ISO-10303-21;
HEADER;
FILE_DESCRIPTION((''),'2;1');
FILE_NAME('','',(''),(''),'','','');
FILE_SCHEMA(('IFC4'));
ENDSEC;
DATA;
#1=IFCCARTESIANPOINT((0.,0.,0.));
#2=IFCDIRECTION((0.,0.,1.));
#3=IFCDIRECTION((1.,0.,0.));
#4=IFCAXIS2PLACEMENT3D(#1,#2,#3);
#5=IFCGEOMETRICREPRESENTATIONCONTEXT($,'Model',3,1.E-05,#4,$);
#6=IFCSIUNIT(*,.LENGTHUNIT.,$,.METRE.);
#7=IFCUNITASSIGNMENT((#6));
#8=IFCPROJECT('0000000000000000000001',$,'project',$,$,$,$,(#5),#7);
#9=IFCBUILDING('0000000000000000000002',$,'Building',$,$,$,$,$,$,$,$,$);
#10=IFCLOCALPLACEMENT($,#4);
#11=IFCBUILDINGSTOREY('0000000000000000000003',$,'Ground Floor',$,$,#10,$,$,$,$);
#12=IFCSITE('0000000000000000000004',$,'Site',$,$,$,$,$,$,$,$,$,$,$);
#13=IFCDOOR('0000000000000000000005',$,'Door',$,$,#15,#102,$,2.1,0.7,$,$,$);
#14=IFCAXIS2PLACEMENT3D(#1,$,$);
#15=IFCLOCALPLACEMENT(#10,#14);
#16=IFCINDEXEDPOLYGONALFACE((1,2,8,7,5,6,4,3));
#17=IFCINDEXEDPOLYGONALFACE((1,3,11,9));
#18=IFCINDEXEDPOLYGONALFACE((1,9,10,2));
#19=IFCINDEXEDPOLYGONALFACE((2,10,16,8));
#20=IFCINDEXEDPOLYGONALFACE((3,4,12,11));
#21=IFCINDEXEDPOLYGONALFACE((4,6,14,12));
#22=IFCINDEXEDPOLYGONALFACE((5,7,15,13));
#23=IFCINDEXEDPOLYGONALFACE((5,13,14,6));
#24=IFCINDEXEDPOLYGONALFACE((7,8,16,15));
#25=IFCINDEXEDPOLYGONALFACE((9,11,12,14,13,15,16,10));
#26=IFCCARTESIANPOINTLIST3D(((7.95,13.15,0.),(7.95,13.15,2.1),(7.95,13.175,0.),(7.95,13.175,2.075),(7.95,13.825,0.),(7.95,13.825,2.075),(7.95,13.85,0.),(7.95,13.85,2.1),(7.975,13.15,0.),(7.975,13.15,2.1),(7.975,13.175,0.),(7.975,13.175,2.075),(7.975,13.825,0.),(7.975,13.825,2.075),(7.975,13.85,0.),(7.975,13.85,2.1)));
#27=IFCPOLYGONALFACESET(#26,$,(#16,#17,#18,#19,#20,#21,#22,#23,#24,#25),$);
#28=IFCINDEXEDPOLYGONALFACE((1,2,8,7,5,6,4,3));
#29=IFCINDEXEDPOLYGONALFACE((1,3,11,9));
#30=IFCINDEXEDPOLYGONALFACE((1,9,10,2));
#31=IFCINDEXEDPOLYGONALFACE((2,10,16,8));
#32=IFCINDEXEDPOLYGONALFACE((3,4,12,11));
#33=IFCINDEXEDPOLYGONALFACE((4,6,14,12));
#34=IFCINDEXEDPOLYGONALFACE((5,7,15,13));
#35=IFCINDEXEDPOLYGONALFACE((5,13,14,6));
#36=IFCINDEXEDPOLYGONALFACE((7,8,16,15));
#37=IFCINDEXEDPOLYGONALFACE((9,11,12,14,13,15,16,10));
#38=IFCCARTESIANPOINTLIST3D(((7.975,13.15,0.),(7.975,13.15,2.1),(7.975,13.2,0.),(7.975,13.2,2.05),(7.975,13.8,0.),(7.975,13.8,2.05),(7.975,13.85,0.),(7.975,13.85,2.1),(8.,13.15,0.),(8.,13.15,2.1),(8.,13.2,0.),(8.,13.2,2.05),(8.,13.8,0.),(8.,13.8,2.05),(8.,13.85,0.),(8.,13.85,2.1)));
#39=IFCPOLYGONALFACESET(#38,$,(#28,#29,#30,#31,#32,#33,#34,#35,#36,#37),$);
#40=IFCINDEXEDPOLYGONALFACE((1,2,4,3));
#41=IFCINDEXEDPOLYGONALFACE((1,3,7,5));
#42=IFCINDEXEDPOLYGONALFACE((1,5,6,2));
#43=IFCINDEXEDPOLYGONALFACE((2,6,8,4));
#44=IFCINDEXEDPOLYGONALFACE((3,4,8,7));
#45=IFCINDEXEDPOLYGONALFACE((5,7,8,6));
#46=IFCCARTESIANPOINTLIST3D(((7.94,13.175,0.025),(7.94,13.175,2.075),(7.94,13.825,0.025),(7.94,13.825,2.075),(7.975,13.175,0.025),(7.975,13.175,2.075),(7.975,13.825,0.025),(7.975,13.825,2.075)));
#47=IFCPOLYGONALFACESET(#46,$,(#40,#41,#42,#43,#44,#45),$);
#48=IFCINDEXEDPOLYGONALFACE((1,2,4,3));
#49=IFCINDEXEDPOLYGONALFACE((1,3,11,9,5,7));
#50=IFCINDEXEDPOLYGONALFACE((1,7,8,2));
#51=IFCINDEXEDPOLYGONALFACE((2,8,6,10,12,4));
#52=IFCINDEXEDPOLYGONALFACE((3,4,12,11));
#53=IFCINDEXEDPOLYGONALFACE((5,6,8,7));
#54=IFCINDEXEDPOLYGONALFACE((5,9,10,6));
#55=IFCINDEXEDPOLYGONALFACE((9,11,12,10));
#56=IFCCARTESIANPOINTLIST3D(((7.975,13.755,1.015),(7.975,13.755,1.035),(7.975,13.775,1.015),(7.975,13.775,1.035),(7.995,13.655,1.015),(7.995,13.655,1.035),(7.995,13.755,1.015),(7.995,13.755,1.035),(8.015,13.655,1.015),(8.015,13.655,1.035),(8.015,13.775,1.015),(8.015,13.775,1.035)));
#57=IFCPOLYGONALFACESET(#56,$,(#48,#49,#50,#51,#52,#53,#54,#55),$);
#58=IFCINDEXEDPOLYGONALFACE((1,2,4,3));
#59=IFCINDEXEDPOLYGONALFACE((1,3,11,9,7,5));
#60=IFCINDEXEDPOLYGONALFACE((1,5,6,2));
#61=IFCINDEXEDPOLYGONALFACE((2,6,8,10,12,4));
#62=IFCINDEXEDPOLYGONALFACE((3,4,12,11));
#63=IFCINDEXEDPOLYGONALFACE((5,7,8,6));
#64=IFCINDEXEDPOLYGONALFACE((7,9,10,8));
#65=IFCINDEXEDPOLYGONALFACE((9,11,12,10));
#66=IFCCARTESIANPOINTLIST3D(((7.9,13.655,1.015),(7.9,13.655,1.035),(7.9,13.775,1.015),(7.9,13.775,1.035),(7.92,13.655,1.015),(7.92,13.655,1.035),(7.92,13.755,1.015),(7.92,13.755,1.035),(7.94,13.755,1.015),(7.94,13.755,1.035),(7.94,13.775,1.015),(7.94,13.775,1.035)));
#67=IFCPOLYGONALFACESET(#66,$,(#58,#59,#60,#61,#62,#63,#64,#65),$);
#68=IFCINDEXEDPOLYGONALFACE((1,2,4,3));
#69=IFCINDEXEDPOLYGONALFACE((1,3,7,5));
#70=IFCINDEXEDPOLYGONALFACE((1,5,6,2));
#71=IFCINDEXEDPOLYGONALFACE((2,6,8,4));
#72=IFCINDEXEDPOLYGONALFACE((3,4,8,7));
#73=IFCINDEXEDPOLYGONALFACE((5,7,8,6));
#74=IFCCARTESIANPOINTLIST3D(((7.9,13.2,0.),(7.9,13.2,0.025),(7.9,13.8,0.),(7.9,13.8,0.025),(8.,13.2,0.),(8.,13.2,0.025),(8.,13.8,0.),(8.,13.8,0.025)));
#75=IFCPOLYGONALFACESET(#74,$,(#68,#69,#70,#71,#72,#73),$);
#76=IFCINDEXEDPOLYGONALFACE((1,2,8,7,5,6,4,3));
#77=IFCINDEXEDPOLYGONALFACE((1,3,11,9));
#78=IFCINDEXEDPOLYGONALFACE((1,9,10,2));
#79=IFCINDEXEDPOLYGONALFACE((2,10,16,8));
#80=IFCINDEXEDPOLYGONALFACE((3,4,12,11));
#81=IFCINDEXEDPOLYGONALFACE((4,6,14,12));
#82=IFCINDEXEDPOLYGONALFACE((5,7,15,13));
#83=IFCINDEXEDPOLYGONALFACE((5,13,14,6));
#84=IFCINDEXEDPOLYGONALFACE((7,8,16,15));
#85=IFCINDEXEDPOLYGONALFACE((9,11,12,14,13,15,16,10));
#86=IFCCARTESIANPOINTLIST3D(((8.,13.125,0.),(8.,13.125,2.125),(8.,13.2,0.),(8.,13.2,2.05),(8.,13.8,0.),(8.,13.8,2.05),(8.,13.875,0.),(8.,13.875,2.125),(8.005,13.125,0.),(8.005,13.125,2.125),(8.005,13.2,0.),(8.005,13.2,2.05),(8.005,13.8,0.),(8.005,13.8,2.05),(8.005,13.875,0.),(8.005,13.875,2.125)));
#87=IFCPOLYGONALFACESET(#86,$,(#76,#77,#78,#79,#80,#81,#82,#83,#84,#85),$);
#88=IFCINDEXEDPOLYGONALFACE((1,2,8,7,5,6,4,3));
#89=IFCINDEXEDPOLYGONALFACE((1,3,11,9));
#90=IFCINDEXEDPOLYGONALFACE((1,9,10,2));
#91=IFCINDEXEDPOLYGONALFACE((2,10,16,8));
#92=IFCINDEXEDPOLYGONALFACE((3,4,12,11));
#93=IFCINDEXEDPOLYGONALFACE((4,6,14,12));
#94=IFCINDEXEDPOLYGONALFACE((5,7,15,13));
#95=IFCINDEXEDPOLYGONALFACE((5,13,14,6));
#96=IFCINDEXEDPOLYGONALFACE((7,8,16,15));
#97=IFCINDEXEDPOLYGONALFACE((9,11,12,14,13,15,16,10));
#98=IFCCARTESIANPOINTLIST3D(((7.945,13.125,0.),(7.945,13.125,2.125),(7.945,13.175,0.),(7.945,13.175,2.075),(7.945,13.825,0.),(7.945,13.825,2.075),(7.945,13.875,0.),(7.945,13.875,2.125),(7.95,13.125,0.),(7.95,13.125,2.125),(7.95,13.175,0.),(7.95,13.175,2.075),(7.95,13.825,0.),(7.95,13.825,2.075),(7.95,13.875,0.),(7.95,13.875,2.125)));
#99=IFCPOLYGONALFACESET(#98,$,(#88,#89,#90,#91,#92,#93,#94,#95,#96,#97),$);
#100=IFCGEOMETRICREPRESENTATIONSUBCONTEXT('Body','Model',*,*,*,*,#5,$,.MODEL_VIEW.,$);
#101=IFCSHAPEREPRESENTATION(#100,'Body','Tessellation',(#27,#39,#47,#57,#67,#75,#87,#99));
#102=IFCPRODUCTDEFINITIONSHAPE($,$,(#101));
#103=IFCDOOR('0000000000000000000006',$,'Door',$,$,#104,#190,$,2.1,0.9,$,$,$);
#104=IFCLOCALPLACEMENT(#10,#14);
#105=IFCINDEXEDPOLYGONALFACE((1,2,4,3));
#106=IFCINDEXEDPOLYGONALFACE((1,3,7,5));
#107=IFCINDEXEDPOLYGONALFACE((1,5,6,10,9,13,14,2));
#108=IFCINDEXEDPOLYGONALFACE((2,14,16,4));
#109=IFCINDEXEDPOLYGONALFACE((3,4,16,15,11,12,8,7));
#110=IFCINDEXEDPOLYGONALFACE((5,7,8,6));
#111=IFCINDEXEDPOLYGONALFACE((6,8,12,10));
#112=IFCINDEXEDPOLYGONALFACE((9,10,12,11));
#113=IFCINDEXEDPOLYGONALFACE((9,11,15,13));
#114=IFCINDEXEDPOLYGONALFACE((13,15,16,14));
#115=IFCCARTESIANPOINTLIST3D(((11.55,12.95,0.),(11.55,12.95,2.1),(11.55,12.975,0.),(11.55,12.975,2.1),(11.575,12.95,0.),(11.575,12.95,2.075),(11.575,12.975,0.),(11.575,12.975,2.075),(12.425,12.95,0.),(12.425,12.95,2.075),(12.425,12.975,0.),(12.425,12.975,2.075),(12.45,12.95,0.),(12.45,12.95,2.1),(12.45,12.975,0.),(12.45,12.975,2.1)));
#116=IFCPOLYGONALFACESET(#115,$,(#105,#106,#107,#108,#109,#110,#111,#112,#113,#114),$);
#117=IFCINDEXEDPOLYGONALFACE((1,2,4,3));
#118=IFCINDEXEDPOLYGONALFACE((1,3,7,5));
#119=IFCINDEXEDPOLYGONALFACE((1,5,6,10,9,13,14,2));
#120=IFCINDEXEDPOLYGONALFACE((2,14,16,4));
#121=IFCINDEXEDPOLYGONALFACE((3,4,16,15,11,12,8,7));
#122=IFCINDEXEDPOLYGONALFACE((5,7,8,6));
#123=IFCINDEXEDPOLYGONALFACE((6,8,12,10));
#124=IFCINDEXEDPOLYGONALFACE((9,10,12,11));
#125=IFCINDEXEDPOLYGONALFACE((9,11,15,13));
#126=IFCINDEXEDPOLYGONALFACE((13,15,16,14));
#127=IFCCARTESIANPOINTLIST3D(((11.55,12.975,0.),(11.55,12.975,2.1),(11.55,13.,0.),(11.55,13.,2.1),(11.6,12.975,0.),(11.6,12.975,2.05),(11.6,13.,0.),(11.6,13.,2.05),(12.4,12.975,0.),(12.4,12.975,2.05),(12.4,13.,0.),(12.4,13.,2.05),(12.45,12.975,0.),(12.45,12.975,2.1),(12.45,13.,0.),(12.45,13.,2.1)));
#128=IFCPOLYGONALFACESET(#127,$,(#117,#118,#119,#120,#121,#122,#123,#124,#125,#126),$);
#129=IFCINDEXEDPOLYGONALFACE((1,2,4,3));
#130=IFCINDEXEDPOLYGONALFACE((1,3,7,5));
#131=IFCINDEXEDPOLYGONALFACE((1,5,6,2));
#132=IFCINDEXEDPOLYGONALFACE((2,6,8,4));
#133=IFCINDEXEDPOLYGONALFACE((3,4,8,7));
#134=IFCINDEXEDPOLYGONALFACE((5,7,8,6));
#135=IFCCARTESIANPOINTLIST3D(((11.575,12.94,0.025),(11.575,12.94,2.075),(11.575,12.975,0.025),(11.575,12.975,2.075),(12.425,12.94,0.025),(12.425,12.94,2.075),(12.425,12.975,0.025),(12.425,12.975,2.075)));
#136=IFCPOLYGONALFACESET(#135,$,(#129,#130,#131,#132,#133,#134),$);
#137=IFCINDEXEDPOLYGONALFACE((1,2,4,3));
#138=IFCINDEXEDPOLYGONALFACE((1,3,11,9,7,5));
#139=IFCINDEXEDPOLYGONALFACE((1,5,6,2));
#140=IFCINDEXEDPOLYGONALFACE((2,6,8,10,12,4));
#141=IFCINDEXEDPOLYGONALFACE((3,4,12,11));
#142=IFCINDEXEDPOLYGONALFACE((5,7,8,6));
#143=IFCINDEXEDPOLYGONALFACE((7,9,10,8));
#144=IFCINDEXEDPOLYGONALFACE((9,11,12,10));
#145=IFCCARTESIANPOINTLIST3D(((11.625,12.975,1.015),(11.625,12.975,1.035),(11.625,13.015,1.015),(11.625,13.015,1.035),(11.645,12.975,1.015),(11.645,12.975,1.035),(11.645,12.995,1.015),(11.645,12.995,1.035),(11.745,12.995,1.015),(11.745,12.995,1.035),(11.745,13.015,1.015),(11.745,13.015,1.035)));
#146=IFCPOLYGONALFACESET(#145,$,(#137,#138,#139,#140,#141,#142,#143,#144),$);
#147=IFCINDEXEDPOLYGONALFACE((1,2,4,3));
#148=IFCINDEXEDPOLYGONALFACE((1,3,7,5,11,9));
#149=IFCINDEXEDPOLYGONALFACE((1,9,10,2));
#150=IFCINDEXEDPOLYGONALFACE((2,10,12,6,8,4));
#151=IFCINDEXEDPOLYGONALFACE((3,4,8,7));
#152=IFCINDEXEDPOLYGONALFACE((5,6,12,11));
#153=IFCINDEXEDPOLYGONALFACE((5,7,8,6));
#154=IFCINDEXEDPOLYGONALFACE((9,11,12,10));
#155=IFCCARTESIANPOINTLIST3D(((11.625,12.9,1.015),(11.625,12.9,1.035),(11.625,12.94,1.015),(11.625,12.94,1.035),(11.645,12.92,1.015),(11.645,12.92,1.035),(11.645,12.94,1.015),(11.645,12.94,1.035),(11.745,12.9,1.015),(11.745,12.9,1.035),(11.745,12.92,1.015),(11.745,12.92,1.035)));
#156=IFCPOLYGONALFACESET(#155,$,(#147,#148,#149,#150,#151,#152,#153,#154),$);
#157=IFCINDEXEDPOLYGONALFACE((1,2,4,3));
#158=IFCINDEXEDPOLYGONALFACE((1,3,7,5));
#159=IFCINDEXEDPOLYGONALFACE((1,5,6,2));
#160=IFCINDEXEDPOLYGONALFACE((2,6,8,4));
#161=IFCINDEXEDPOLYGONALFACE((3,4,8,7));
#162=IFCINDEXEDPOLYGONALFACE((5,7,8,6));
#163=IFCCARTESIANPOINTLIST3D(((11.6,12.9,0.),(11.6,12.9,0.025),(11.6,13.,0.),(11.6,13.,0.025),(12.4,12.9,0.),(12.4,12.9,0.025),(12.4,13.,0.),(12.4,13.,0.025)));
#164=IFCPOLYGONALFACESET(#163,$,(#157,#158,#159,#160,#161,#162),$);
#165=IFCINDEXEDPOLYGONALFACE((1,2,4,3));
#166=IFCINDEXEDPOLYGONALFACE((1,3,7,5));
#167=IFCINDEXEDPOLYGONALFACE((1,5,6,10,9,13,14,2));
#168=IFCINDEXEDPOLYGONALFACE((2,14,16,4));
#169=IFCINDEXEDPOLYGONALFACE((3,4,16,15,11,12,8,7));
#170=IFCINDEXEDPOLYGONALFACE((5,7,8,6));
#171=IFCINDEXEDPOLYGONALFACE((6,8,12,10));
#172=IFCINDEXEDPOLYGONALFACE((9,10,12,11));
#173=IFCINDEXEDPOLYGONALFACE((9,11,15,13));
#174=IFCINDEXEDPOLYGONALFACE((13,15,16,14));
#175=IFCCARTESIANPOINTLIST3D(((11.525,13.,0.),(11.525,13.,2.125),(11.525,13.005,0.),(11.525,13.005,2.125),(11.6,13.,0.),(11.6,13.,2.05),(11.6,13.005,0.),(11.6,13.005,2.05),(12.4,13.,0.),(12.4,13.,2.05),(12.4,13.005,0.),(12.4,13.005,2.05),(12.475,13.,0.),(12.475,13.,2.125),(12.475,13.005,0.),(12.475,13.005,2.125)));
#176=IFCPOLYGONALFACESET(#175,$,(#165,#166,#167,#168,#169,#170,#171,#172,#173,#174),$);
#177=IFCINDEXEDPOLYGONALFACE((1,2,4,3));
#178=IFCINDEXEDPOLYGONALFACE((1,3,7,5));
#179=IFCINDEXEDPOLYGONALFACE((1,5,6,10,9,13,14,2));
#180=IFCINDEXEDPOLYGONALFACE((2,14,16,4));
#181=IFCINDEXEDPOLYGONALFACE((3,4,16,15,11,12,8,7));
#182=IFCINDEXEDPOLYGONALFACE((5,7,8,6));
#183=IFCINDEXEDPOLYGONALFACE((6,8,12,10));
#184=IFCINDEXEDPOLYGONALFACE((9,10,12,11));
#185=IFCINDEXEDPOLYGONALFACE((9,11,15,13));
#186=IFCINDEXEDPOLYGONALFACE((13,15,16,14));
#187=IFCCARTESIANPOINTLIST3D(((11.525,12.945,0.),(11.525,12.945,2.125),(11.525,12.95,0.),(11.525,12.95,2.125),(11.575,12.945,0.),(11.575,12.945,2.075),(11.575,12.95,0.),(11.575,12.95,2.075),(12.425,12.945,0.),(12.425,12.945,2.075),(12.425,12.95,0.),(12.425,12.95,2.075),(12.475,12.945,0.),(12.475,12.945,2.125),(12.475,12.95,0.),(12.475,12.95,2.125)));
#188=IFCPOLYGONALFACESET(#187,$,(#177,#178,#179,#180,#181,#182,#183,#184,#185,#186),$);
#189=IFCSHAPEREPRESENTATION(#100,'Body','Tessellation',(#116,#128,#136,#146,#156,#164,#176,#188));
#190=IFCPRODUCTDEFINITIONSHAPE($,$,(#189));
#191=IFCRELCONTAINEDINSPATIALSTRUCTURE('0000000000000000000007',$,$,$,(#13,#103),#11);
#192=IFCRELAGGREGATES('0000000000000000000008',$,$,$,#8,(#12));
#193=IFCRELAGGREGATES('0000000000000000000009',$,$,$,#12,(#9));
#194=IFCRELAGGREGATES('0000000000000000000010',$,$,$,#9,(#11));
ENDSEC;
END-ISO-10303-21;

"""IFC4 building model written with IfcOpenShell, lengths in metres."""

from ifc_helpers import new_model, si_unit, frame, origin_with_axes, place, context, subcontext, project, spatial, line, indexed_curve, outline, extrude, element, save


model = new_model("IFC4")

# Units and contexts
model_context = context("Model", 3, precision=1e-05, world=origin_with_axes())
body_context = subcontext(model_context, "Body", "Model", "MODEL_VIEW")
ifc_project = project(units=[si_unit("LENGTHUNIT", "METRE")], contexts=[model_context])

# Site, building, storey
site = spatial("IfcSite", under=ifc_project, Name="Site")
building = spatial("IfcBuilding", under=site, Name="Building")
storey_placement = place(None, origin_with_axes())
storey = spatial("IfcBuildingStorey", under=building, at=storey_placement, Name="Ground Floor")

# Doors
door_1_placement = place(storey_placement, frame((8.0, 13.15, 0.0), z_axis=(0.0, 0.0, 1.0), x_axis=(0.0, 1.0, 0.0)))
element("IfcDoor", 1, at=door_1_placement, inside=storey, Name="Door", OverallHeight=2.1, OverallWidth=0.7, context=body_context, shape_type="SweptSolid", body=[
    extrude(outline(indexed_curve([(0.0, 0.0), (0.0, 2.1), (0.7, 2.1), (0.7, 0.0), (0.675, 0.0), (0.675, 2.075), (0.025, 2.075), (0.025, 0.0)], segments=[line(1, 2, 3, 4, 5, 6, 7, 8, 1)])), frame((0.0, 0.025, 0.0), z_axis=(0.0, -1.0, 0.0), x_axis=(1.0, 0.0, 0.0)), (0.0, 0.0, -1.0), 0.025),
    extrude(outline(indexed_curve([(0.0, 0.0), (0.0, 2.1), (0.7, 2.1), (0.7, 0.0), (0.65, 0.0), (0.65, 2.05), (0.05, 2.05), (0.05, 0.0)], segments=[line(1, 2, 3, 4, 5, 6, 7, 8, 1)])), frame((0.0, 0.0, 0.0), z_axis=(0.0, -1.0, 0.0), x_axis=(1.0, 0.0, 0.0)), (0.0, 0.0, -1.0), 0.025),
    extrude(outline(indexed_curve([(0.0, 0.0), (0.65, 0.0), (0.65, 0.035), (0.0, 0.035)], segments=[line(1, 2, 3, 4, 1)])), frame((0.025, 0.025, 0.025), z_axis=(0.0, 0.0, 1.0), x_axis=(1.0, 0.0, 0.0)), (0.0, 0.0, 1.0), 2.05),
    extrude(outline(indexed_curve([(0.0, 0.0), (0.0, -0.04), (-0.12, -0.04), (-0.12, -0.02), (-0.02, -0.02), (-0.02, 0.0)], segments=[line(1, 2, 3, 4, 5, 6, 1)])), frame((0.625, 0.025, 1.015), z_axis=(0.0, 0.0, 1.0), x_axis=(1.0, 0.0, 0.0)), (0.0, 0.0, 1.0), 0.02),
    extrude(outline(indexed_curve([(0.0, 0.0), (0.0, 0.04), (-0.12, 0.04), (-0.12, 0.02), (-0.02, 0.02), (-0.02, 0.0)], segments=[line(1, 2, 3, 4, 5, 6, 1)])), frame((0.625, 0.06, 1.015), z_axis=(0.0, 0.0, 1.0), x_axis=(1.0, 0.0, 0.0)), (0.0, 0.0, 1.0), 0.02),
    extrude(outline(indexed_curve([(0.0, 0.0), (0.6, 0.0), (0.6, 0.1), (0.0, 0.1)], segments=[line(1, 2, 3, 4, 1)])), frame((0.05, 0.0, 0.0), z_axis=(0.0, 0.0, 1.0), x_axis=(1.0, 0.0, 0.0)), (0.0, 0.0, 1.0), 0.025),
    extrude(outline(indexed_curve([(0.0, 0.0), (0.0, 2.125), (0.75, 2.125), (0.75, 0.0), (0.675, 0.0), (0.675, 2.05), (0.075, 2.05), (0.075, 0.0)], segments=[line(1, 2, 3, 4, 5, 6, 7, 8, 1)])), frame((-0.025, -0.005, 0.0), z_axis=(0.0, -1.0, 0.0), x_axis=(1.0, 0.0, 0.0)), (0.0, 0.0, -1.0), 0.005),
    extrude(outline(indexed_curve([(0.0, 0.0), (0.0, 2.125), (0.75, 2.125), (0.75, 0.0), (0.7, 0.0), (0.7, 2.075), (0.05, 2.075), (0.05, 0.0)], segments=[line(1, 2, 3, 4, 5, 6, 7, 8, 1)])), frame((-0.025, 0.05, 0.0), z_axis=(0.0, -1.0, 0.0), x_axis=(1.0, 0.0, 0.0)), (0.0, 0.0, -1.0), 0.005),
])
door_2_placement = place(storey_placement, frame((12.45, 13.0, 0.0), z_axis=(0.0, 0.0, 1.0), x_axis=(-1.0, 0.0, 0.0)))
element("IfcDoor", 2, at=door_2_placement, inside=storey, Name="Door", OverallHeight=2.1, OverallWidth=0.9, context=body_context, shape_type="SweptSolid", body=[
    extrude(outline(indexed_curve([(0.0, 0.0), (0.0, 2.1), (0.9, 2.1), (0.9, 0.0), (0.875, 0.0), (0.875, 2.075), (0.025, 2.075), (0.025, 0.0)], segments=[line(1, 2, 3, 4, 5, 6, 7, 8, 1)])), frame((0.0, 0.025, 0.0), z_axis=(0.0, -1.0, 0.0), x_axis=(1.0, 0.0, 0.0)), (0.0, 0.0, -1.0), 0.025),
    extrude(outline(indexed_curve([(0.0, 0.0), (0.0, 2.1), (0.9, 2.1), (0.9, 0.0), (0.85, 0.0), (0.85, 2.05), (0.05, 2.05), (0.05, 0.0)], segments=[line(1, 2, 3, 4, 5, 6, 7, 8, 1)])), frame((0.0, 0.0, 0.0), z_axis=(0.0, -1.0, 0.0), x_axis=(1.0, 0.0, 0.0)), (0.0, 0.0, -1.0), 0.025),
    extrude(outline(indexed_curve([(0.0, 0.0), (0.85, 0.0), (0.85, 0.035), (0.0, 0.035)], segments=[line(1, 2, 3, 4, 1)])), frame((0.025, 0.025, 0.025), z_axis=(0.0, 0.0, 1.0), x_axis=(1.0, 0.0, 0.0)), (0.0, 0.0, 1.0), 2.05),
    extrude(outline(indexed_curve([(0.0, 0.0), (0.0, -0.04), (-0.12, -0.04), (-0.12, -0.02), (-0.02, -0.02), (-0.02, 0.0)], segments=[line(1, 2, 3, 4, 5, 6, 1)])), frame((0.825, 0.025, 1.015), z_axis=(0.0, 0.0, 1.0), x_axis=(1.0, 0.0, 0.0)), (0.0, 0.0, 1.0), 0.02),
    extrude(outline(indexed_curve([(0.0, 0.0), (0.0, 0.04), (-0.12, 0.04), (-0.12, 0.02), (-0.02, 0.02), (-0.02, 0.0)], segments=[line(1, 2, 3, 4, 5, 6, 1)])), frame((0.825, 0.06, 1.015), z_axis=(0.0, 0.0, 1.0), x_axis=(1.0, 0.0, 0.0)), (0.0, 0.0, 1.0), 0.02),
    extrude(outline(indexed_curve([(0.0, 0.0), (0.8, 0.0), (0.8, 0.1), (0.0, 0.1)], segments=[line(1, 2, 3, 4, 1)])), frame((0.05, 0.0, 0.0), z_axis=(0.0, 0.0, 1.0), x_axis=(1.0, 0.0, 0.0)), (0.0, 0.0, 1.0), 0.025),
    extrude(outline(indexed_curve([(0.0, 0.0), (0.0, 2.125), (0.95, 2.125), (0.95, 0.0), (0.875, 0.0), (0.875, 2.05), (0.075, 2.05), (0.075, 0.0)], segments=[line(1, 2, 3, 4, 5, 6, 7, 8, 1)])), frame((-0.025, -0.005, 0.0), z_axis=(0.0, -1.0, 0.0), x_axis=(1.0, 0.0, 0.0)), (0.0, 0.0, -1.0), 0.005),
    extrude(outline(indexed_curve([(0.0, 0.0), (0.0, 2.125), (0.95, 2.125), (0.95, 0.0), (0.9, 0.0), (0.9, 2.075), (0.05, 2.075), (0.05, 0.0)], segments=[line(1, 2, 3, 4, 5, 6, 7, 8, 1)])), frame((-0.025, 0.05, 0.0), z_axis=(0.0, -1.0, 0.0), x_axis=(1.0, 0.0, 0.0)), (0.0, 0.0, -1.0), 0.005),
])

save(model, "model.ifc")
